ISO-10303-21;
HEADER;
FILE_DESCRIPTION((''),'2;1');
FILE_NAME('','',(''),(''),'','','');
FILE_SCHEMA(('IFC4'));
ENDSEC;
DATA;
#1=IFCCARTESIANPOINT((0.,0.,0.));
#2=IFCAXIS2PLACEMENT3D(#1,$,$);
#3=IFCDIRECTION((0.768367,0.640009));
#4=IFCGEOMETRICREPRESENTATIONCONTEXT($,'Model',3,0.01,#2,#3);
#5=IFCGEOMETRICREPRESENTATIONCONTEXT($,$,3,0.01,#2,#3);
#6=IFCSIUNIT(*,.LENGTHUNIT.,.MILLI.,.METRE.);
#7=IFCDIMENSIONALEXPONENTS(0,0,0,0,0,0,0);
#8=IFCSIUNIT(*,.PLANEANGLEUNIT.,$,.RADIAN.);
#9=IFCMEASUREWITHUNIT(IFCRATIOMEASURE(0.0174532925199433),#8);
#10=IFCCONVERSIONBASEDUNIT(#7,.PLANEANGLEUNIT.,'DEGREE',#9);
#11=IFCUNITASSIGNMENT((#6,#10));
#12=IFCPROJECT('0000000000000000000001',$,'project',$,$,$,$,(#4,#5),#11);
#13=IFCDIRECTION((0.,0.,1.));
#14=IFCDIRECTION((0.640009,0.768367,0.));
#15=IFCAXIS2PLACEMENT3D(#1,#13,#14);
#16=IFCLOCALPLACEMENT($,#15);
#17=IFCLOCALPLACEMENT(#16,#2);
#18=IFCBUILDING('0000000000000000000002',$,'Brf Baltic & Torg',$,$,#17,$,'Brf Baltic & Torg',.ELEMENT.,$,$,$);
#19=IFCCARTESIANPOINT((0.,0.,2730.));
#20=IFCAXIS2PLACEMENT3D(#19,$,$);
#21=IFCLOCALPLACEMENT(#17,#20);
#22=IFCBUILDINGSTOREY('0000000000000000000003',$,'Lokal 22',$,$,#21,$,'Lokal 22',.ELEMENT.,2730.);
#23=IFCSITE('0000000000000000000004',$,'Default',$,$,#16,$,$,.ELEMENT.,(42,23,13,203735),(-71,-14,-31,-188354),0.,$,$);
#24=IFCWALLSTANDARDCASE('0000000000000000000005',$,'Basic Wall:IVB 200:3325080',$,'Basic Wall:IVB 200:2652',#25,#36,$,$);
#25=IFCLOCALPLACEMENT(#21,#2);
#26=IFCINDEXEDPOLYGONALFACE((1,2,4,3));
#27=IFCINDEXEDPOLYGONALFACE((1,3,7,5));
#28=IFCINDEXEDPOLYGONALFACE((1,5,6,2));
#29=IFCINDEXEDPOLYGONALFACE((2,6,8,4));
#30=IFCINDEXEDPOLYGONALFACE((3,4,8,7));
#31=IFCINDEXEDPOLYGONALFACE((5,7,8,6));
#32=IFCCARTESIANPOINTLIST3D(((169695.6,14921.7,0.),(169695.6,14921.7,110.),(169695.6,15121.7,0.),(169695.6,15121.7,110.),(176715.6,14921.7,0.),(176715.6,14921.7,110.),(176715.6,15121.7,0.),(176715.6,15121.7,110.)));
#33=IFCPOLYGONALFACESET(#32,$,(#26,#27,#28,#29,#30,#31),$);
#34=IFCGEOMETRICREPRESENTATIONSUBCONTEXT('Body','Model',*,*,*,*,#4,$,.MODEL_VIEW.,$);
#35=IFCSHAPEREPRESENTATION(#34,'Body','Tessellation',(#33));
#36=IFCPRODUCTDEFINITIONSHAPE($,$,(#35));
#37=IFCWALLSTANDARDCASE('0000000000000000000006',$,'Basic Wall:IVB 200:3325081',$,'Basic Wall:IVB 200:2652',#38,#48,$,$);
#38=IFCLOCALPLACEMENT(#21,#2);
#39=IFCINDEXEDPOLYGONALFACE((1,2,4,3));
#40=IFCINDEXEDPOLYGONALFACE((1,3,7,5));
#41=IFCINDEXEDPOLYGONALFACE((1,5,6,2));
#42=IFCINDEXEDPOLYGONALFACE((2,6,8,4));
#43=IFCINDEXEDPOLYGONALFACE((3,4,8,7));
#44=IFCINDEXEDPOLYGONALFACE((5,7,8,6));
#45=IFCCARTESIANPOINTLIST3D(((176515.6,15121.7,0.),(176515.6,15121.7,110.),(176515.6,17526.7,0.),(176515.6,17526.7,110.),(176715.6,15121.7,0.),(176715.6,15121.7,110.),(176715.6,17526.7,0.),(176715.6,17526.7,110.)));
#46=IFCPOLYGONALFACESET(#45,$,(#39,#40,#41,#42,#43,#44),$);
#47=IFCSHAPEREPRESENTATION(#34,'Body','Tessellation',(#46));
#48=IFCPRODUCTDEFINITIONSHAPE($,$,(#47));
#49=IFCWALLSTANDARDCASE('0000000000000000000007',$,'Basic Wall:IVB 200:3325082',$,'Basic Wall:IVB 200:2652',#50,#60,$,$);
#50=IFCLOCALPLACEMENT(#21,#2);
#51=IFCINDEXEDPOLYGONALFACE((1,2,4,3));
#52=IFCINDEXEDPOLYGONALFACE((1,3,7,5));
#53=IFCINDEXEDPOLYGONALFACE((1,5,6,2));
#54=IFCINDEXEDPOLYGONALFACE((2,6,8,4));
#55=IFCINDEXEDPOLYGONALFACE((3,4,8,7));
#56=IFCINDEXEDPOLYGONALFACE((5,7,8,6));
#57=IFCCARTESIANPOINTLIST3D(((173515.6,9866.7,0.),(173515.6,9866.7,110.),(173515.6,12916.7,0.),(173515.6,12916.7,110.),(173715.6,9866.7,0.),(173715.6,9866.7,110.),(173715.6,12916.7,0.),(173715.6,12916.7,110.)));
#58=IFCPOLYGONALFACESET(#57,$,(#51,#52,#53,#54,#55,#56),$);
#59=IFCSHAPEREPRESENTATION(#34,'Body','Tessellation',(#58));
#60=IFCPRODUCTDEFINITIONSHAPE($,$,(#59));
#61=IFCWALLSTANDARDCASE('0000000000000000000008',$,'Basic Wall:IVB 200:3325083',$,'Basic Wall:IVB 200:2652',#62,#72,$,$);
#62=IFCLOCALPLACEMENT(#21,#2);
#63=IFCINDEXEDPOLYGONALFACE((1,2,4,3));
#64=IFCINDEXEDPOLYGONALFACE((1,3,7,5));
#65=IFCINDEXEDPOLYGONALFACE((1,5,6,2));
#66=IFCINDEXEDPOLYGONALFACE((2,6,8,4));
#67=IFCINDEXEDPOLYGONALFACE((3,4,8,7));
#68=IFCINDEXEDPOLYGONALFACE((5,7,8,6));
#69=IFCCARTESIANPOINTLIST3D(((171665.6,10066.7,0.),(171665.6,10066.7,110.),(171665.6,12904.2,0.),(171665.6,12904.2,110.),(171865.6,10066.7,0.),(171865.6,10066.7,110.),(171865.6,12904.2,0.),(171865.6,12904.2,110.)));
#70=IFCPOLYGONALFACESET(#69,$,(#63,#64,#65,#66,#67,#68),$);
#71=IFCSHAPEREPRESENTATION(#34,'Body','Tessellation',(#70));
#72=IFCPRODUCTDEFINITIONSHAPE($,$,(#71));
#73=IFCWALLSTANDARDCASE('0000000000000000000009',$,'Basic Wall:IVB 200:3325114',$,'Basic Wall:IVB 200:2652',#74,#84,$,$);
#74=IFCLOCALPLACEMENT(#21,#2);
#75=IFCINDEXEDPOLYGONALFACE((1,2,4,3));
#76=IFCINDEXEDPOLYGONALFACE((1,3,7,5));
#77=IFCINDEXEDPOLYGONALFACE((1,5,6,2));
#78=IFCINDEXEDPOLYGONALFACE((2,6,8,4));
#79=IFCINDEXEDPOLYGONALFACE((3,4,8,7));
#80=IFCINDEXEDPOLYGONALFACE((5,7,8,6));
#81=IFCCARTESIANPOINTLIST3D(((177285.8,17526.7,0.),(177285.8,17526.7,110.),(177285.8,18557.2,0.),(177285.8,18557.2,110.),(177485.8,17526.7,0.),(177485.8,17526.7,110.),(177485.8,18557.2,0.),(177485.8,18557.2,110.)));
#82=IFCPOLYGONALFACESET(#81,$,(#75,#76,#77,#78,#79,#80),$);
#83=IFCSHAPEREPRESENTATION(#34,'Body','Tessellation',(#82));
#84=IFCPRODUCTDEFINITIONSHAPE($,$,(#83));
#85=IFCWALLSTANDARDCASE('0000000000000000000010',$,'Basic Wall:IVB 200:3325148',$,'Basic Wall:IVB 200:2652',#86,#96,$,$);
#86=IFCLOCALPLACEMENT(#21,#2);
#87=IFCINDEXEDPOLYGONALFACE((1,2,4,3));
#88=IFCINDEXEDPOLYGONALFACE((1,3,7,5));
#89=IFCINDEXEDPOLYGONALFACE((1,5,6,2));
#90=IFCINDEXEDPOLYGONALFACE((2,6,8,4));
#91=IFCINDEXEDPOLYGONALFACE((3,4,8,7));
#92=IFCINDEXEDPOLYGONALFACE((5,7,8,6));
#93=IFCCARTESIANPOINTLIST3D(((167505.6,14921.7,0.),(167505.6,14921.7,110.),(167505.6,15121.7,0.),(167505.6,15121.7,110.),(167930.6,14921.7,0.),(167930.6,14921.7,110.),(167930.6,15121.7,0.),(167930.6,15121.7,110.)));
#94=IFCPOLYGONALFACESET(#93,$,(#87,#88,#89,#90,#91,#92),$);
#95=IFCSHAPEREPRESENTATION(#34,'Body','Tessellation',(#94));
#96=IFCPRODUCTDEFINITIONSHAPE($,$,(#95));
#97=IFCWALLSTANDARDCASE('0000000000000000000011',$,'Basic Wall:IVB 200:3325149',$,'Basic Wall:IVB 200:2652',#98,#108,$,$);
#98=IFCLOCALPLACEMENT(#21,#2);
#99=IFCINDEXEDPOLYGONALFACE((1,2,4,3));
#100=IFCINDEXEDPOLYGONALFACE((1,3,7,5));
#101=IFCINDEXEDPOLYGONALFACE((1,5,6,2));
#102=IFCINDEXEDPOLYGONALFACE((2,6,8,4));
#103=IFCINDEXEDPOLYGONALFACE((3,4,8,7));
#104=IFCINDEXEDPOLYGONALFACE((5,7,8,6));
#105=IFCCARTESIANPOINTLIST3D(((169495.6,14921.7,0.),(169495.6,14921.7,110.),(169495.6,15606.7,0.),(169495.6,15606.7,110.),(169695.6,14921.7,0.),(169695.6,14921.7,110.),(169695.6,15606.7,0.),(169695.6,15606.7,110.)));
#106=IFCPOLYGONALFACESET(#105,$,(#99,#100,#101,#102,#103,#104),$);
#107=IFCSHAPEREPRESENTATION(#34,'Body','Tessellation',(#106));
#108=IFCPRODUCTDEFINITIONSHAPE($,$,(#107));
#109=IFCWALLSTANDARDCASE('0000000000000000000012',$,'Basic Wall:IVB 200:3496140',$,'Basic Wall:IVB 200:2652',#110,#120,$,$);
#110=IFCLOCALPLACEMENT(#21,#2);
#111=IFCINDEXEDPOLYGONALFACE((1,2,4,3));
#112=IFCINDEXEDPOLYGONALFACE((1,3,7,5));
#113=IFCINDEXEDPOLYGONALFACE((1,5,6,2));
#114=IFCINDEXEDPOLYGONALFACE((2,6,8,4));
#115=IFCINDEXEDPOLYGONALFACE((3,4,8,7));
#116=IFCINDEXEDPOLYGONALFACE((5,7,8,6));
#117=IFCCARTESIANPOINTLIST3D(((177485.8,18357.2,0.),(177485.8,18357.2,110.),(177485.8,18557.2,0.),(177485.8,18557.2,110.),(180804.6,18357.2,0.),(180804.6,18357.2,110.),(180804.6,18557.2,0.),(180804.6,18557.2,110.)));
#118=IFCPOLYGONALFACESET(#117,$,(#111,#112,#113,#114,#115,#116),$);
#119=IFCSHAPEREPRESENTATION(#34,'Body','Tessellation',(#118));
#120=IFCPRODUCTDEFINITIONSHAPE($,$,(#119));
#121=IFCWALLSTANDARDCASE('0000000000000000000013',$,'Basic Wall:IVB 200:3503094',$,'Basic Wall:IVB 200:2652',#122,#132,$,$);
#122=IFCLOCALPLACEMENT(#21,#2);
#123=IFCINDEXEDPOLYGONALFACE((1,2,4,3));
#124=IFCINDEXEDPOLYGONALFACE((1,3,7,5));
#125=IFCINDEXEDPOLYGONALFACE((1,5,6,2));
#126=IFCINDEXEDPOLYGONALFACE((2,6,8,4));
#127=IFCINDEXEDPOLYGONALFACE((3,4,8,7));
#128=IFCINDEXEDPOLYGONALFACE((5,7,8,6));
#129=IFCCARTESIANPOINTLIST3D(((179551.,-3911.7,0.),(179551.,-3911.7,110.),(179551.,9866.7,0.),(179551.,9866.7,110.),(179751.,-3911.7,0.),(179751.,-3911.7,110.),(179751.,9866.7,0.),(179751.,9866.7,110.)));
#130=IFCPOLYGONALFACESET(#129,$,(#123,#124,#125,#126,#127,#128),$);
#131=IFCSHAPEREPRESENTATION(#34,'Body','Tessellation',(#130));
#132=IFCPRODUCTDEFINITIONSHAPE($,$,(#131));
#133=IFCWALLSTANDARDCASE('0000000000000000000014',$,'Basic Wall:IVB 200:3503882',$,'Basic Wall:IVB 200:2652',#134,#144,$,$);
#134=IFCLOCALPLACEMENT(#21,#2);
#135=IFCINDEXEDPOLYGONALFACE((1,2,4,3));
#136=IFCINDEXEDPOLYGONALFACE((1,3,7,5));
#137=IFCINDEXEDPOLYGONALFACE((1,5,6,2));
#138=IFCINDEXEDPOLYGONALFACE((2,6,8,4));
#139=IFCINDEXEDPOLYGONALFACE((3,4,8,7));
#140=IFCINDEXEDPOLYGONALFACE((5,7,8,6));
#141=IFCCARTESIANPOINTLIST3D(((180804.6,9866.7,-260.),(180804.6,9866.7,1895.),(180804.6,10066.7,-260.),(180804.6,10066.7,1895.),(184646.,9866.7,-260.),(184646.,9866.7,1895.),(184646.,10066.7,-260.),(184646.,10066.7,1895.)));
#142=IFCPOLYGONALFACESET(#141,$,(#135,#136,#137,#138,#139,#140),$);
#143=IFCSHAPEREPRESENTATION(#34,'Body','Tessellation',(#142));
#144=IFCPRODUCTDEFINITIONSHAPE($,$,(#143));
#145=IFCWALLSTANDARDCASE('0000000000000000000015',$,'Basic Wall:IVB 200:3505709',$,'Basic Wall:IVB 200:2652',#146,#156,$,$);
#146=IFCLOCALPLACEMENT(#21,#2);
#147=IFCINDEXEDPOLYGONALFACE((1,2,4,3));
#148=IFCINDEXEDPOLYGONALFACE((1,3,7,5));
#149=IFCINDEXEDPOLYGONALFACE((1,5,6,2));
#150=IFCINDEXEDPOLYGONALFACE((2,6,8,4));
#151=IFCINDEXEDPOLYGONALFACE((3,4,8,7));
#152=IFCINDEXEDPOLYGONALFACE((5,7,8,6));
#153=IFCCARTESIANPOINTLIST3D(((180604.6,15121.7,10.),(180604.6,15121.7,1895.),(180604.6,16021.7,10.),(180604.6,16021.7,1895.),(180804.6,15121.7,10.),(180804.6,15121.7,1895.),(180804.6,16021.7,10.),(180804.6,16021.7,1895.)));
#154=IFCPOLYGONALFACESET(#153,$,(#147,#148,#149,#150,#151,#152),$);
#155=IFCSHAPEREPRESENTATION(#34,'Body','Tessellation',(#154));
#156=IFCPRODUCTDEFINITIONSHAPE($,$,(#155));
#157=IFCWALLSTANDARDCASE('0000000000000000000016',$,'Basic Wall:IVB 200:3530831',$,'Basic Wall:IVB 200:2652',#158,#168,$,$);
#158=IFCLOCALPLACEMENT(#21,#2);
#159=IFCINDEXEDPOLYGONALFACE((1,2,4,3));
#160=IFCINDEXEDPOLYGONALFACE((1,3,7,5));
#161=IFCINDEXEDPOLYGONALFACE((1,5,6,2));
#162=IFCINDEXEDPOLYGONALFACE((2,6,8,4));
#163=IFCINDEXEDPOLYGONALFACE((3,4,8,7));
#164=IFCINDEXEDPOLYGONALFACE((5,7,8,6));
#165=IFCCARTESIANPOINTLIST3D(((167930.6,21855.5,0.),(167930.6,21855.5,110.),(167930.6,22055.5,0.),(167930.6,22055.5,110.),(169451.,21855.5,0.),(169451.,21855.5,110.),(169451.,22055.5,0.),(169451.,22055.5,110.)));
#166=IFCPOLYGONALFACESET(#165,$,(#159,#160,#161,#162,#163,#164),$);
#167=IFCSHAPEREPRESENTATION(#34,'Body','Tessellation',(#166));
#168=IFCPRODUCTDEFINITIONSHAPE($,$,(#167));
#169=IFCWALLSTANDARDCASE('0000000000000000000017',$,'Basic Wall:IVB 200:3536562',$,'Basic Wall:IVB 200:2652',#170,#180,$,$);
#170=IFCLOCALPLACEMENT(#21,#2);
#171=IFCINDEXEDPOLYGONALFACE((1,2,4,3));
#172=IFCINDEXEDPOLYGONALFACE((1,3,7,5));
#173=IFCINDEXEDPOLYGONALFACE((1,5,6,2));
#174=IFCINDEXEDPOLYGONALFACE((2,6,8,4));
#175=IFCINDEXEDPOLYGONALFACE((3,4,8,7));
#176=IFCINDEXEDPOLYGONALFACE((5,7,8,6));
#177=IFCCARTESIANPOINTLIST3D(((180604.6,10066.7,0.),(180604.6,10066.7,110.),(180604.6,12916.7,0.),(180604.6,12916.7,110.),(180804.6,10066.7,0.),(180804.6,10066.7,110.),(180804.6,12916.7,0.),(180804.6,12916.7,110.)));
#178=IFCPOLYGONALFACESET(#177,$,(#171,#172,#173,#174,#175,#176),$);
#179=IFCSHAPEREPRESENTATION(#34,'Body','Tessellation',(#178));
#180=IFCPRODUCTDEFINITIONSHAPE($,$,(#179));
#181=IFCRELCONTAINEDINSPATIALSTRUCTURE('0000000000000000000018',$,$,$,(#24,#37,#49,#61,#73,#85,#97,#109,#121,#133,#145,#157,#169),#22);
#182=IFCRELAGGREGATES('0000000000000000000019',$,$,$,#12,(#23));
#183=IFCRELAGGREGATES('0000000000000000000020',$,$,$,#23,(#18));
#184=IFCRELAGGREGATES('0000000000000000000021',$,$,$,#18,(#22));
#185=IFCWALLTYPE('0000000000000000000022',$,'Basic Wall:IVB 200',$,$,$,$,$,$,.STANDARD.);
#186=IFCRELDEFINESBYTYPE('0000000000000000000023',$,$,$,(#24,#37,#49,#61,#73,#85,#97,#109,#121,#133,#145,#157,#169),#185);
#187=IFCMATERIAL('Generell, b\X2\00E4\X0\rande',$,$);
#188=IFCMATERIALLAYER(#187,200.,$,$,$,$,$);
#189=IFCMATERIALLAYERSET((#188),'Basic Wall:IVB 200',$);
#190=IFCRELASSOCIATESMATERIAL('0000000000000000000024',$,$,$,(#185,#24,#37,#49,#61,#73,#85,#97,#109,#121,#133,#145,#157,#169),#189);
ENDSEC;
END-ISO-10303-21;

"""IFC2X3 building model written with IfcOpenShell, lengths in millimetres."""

from ifc_helpers import new_model, entity, si_unit, converted_unit, direction, frame, frame_2d, origin, place, context, subcontext, project, spatial, rectangle, extrude, clip, halfspace, material, layer, layer_set, layer_usage, type_object, element, save


model = new_model("IFC2X3")

# Units and contexts
model_context = context("Model", 3, precision=0.01, world=origin(), true_north=direction((0.768367, 0.640009)))
context_of_model = context(None, 3, precision=0.01, world=origin(), true_north=direction((0.768367, 0.640009)))
body_context = subcontext(model_context, "Body", "Model", "MODEL_VIEW")
ifc_project = project(units=[si_unit("LENGTHUNIT", "METRE", prefix="MILLI"), converted_unit("PLANEANGLEUNIT", "DEGREE", entity("IfcRatioMeasure", 0.0174532925199433), si_unit("PLANEANGLEUNIT", "RADIAN"), dimensions=[0, 0, 0, 0, 0, 0, 0])], contexts=[model_context, context_of_model])

# Site, building, storey
site_placement = place(None, frame((0.0, 0.0, 0.0), z_axis=(0.0, 0.0, 1.0), x_axis=(0.640009, 0.768367, 0.0)))
site = spatial("IfcSite", under=ifc_project, at=site_placement, Name="Default", CompositionType="ELEMENT", RefLatitude=(42, 23, 13, 203735), RefLongitude=(-71, -14, -31, -188354), RefElevation=0.0)
building_placement = place(site_placement, origin())
building = spatial("IfcBuilding", under=site, at=building_placement, Name="Brf Baltic & Torg", LongName="Brf Baltic & Torg", CompositionType="ELEMENT")
storey_placement = place(building_placement, frame((0.0, 0.0, 2730.0)))
storey = spatial("IfcBuildingStorey", under=building, at=storey_placement, Name="Lokal 22", LongName="Lokal 22", CompositionType="ELEMENT", Elevation=2730.0)

# Walls
ifc_material = material(Name="Generell, bärande")
ifc_layer = layer(ifc_material, 200.0)
ifc_layer_set = layer_set([ifc_layer], Name="Basic Wall:IVB 200")
ifc_layer_usage_1 = layer_usage(ifc_layer_set, "AXIS2", "NEGATIVE", 100.0)
wall_type = type_object("IfcWallType", Name="Basic Wall:IVB 200", PredefinedType="STANDARD", material=ifc_layer_set)
wall_1_placement = place(storey_placement, frame((169695.6, 15021.7, 0.0)))
element("IfcWallStandardCase", 1, at=wall_1_placement, inside=storey, type_object=wall_type, material=ifc_layer_usage_1, Name="Basic Wall:IVB 200:3325080", ObjectType="Basic Wall:IVB 200:2652", context=body_context, shape_type="Clipping", body=[
    clip(extrude(rectangle(XDim=7020.0, YDim=200.0, at=frame_2d((3510.0, 0.0), x_axis=(-1.0, 0.0))), origin(), (0.0, 0.0, 1.0), 110.0), halfspace(frame((0.0, 0.0, -1080.0)), True)),
])
ifc_layer_usage_2 = layer_usage(ifc_layer_set, "AXIS2", "NEGATIVE", 100.0)
wall_2_placement = place(storey_placement, frame((176615.6, 15121.7, 0.0), z_axis=(0.0, 0.0, 1.0), x_axis=(0.0, 1.0, 0.0)))
element("IfcWallStandardCase", 2, at=wall_2_placement, inside=storey, type_object=wall_type, material=ifc_layer_usage_2, Name="Basic Wall:IVB 200:3325081", ObjectType="Basic Wall:IVB 200:2652", context=body_context, shape_type="Clipping", body=[
    clip(extrude(rectangle(XDim=2405.0, YDim=200.0, at=frame_2d((1202.5, 0.0), x_axis=(-1.0, 0.0))), origin(), (0.0, 0.0, 1.0), 110.0), halfspace(frame((0.0, 0.0, -1080.0)), True)),
])
ifc_layer_usage_3 = layer_usage(ifc_layer_set, "AXIS2", "NEGATIVE", 100.0)
wall_3_placement = place(storey_placement, frame((173615.6, 9866.7, 0.0), z_axis=(0.0, 0.0, 1.0), x_axis=(0.0, 1.0, 0.0)))
element("IfcWallStandardCase", 3, at=wall_3_placement, inside=storey, type_object=wall_type, material=ifc_layer_usage_3, Name="Basic Wall:IVB 200:3325082", ObjectType="Basic Wall:IVB 200:2652", context=body_context, shape_type="Clipping", body=[
    clip(extrude(rectangle(XDim=3050.0, YDim=200.0, at=frame_2d((1525.0, 0.0), x_axis=(-1.0, 0.0))), origin(), (0.0, 0.0, 1.0), 110.0), halfspace(frame((0.0, 0.0, -1080.0)), True)),
])
ifc_layer_usage_4 = layer_usage(ifc_layer_set, "AXIS2", "NEGATIVE", 100.0)
wall_4_placement = place(storey_placement, frame((171765.6, 10066.7, 0.0), z_axis=(0.0, 0.0, 1.0), x_axis=(0.0, 1.0, 0.0)))
element("IfcWallStandardCase", 4, at=wall_4_placement, inside=storey, type_object=wall_type, material=ifc_layer_usage_4, Name="Basic Wall:IVB 200:3325083", ObjectType="Basic Wall:IVB 200:2652", context=body_context, shape_type="Clipping", body=[
    clip(extrude(rectangle(XDim=2837.5, YDim=200.0, at=frame_2d((1418.8, 0.0), x_axis=(-1.0, 0.0))), origin(), (0.0, 0.0, 1.0), 110.0), halfspace(frame((0.0, 0.0, -1080.0)), True)),
])

# Wall
ifc_layer_usage_5 = layer_usage(ifc_layer_set, "AXIS2", "NEGATIVE", 100.0)
wall_5_placement = place(storey_placement, frame((177385.8, 17526.7, 0.0), z_axis=(0.0, 0.0, 1.0), x_axis=(0.0, 1.0, 0.0)))
element("IfcWallStandardCase", 5, at=wall_5_placement, inside=storey, type_object=wall_type, material=ifc_layer_usage_5, Name="Basic Wall:IVB 200:3325114", ObjectType="Basic Wall:IVB 200:2652", context=body_context, shape_type="Clipping", body=[
    clip(extrude(rectangle(XDim=1030.5, YDim=200.0, at=frame_2d((515.2, 0.0), x_axis=(-1.0, 0.0))), origin(), (0.0, 0.0, 1.0), 110.0), halfspace(frame((0.0, 0.0, -1080.0)), True)),
])

# Walls
ifc_layer_usage_6 = layer_usage(ifc_layer_set, "AXIS2", "POSITIVE", -100.0)
wall_6_placement = place(storey_placement, frame((167930.6, 15021.7, 0.0), z_axis=(0.0, 0.0, 1.0), x_axis=(-1.0, 0.0, 0.0)))
element("IfcWallStandardCase", 6, at=wall_6_placement, inside=storey, type_object=wall_type, material=ifc_layer_usage_6, Name="Basic Wall:IVB 200:3325148", ObjectType="Basic Wall:IVB 200:2652", context=body_context, shape_type="Clipping", body=[
    clip(extrude(rectangle(XDim=425.0, YDim=200.0, at=frame_2d((212.5, 0.0), x_axis=(-1.0, 0.0))), origin(), (0.0, 0.0, 1.0), 110.0), halfspace(frame((0.0, 0.0, -1080.0)), True)),
])
ifc_layer_usage_7 = layer_usage(ifc_layer_set, "AXIS2", "POSITIVE", -100.0)
wall_7_placement = place(storey_placement, frame((169595.6, 15606.7, 0.0), z_axis=(0.0, 0.0, 1.0), x_axis=(0.0, -1.0, 0.0)))
element("IfcWallStandardCase", 7, at=wall_7_placement, inside=storey, type_object=wall_type, material=ifc_layer_usage_7, Name="Basic Wall:IVB 200:3325149", ObjectType="Basic Wall:IVB 200:2652", context=body_context, shape_type="Clipping", body=[
    clip(extrude(rectangle(XDim=685.0, YDim=200.0, at=frame_2d((342.5, 0.0), x_axis=(-1.0, 0.0))), origin(), (0.0, 0.0, 1.0), 110.0), halfspace(frame((0.0, 0.0, -1080.0)), True)),
])
ifc_layer_usage_8 = layer_usage(ifc_layer_set, "AXIS2", "NEGATIVE", 100.0)
wall_8_placement = place(storey_placement, frame((177485.8, 18457.2, 0.0)))
element("IfcWallStandardCase", 8, at=wall_8_placement, inside=storey, type_object=wall_type, material=ifc_layer_usage_8, Name="Basic Wall:IVB 200:3496140", ObjectType="Basic Wall:IVB 200:2652", context=body_context, shape_type="Clipping", body=[
    clip(extrude(rectangle(XDim=3318.8, YDim=200.0, at=frame_2d((1659.4, 0.0), x_axis=(-1.0, 0.0))), origin(), (0.0, 0.0, 1.0), 110.0), halfspace(frame((0.0, 0.0, -1080.0)), True)),
])
ifc_layer_usage_9 = layer_usage(ifc_layer_set, "AXIS2", "NEGATIVE", 100.0)
wall_9_placement = place(storey_placement, frame((179651.0, 9866.7, 0.0), z_axis=(0.0, 0.0, 1.0), x_axis=(0.0, -1.0, 0.0)))
element("IfcWallStandardCase", 9, at=wall_9_placement, inside=storey, type_object=wall_type, material=ifc_layer_usage_9, Name="Basic Wall:IVB 200:3503094", ObjectType="Basic Wall:IVB 200:2652", context=body_context, shape_type="Clipping", body=[
    clip(extrude(rectangle(XDim=13778.4, YDim=200.0, at=frame_2d((6889.2, 0.0), x_axis=(-1.0, 0.0))), origin(), (0.0, 0.0, 1.0), 110.0), halfspace(frame((0.0, 0.0, -1080.0)), True)),
])

# Walls
ifc_layer_usage_10 = layer_usage(ifc_layer_set, "AXIS2", "NEGATIVE", 100.0)
wall_10_placement = place(storey_placement, frame((184646.0, 9966.7, -260.0), z_axis=(0.0, 0.0, 1.0), x_axis=(-1.0, 0.0, 0.0)))
element("IfcWallStandardCase", 10, at=wall_10_placement, inside=storey, type_object=wall_type, material=ifc_layer_usage_10, Name="Basic Wall:IVB 200:3503882", ObjectType="Basic Wall:IVB 200:2652", context=body_context, shape_type="SweptSolid", body=[
    extrude(rectangle(XDim=3841.4, YDim=200.0, at=frame_2d((1920.7, 0.0), x_axis=(-1.0, 0.0))), origin(), (0.0, 0.0, 1.0), 2155.0),
])
ifc_layer_usage_11 = layer_usage(ifc_layer_set, "AXIS2", "POSITIVE", -100.0)
wall_11_placement = place(storey_placement, frame((180704.6, 15121.7, 10.0), z_axis=(0.0, 0.0, 1.0), x_axis=(0.0, 1.0, 0.0)))
element("IfcWallStandardCase", 11, at=wall_11_placement, inside=storey, type_object=wall_type, material=ifc_layer_usage_11, Name="Basic Wall:IVB 200:3505709", ObjectType="Basic Wall:IVB 200:2652", context=body_context, shape_type="SweptSolid", body=[
    extrude(rectangle(XDim=900.0, YDim=200.0, at=frame_2d((450.0, 0.0), x_axis=(-1.0, 0.0))), origin(), (0.0, 0.0, 1.0), 1885.0),
])
ifc_layer_usage_12 = layer_usage(ifc_layer_set, "AXIS2", "NEGATIVE", 100.0)
wall_12_placement = place(storey_placement, frame((167930.6, 21955.5, 0.0)))
element("IfcWallStandardCase", 12, at=wall_12_placement, inside=storey, type_object=wall_type, material=ifc_layer_usage_12, Name="Basic Wall:IVB 200:3530831", ObjectType="Basic Wall:IVB 200:2652", context=body_context, shape_type="Clipping", body=[
    clip(extrude(rectangle(XDim=1520.4, YDim=200.0, at=frame_2d((760.2, 0.0), x_axis=(-1.0, 0.0))), origin(), (0.0, 0.0, 1.0), 110.0), halfspace(frame((0.0, 0.0, -1080.0)), True)),
])
ifc_layer_usage_13 = layer_usage(ifc_layer_set, "AXIS2", "POSITIVE", -100.0)
wall_13_placement = place(storey_placement, frame((180704.6, 10066.7, 0.0), z_axis=(0.0, 0.0, 1.0), x_axis=(0.0, 1.0, 0.0)))
element("IfcWallStandardCase", 13, at=wall_13_placement, inside=storey, type_object=wall_type, material=ifc_layer_usage_13, Name="Basic Wall:IVB 200:3536562", ObjectType="Basic Wall:IVB 200:2652", context=body_context, shape_type="Clipping", body=[
    clip(extrude(rectangle(XDim=2850.0, YDim=200.0, at=frame_2d((1425.0, 0.0), x_axis=(-1.0, 0.0))), origin(), (0.0, 0.0, 1.0), 110.0), halfspace(frame((0.0, 0.0, -1080.0)), True)),
])

save(model, "model.ifc")
